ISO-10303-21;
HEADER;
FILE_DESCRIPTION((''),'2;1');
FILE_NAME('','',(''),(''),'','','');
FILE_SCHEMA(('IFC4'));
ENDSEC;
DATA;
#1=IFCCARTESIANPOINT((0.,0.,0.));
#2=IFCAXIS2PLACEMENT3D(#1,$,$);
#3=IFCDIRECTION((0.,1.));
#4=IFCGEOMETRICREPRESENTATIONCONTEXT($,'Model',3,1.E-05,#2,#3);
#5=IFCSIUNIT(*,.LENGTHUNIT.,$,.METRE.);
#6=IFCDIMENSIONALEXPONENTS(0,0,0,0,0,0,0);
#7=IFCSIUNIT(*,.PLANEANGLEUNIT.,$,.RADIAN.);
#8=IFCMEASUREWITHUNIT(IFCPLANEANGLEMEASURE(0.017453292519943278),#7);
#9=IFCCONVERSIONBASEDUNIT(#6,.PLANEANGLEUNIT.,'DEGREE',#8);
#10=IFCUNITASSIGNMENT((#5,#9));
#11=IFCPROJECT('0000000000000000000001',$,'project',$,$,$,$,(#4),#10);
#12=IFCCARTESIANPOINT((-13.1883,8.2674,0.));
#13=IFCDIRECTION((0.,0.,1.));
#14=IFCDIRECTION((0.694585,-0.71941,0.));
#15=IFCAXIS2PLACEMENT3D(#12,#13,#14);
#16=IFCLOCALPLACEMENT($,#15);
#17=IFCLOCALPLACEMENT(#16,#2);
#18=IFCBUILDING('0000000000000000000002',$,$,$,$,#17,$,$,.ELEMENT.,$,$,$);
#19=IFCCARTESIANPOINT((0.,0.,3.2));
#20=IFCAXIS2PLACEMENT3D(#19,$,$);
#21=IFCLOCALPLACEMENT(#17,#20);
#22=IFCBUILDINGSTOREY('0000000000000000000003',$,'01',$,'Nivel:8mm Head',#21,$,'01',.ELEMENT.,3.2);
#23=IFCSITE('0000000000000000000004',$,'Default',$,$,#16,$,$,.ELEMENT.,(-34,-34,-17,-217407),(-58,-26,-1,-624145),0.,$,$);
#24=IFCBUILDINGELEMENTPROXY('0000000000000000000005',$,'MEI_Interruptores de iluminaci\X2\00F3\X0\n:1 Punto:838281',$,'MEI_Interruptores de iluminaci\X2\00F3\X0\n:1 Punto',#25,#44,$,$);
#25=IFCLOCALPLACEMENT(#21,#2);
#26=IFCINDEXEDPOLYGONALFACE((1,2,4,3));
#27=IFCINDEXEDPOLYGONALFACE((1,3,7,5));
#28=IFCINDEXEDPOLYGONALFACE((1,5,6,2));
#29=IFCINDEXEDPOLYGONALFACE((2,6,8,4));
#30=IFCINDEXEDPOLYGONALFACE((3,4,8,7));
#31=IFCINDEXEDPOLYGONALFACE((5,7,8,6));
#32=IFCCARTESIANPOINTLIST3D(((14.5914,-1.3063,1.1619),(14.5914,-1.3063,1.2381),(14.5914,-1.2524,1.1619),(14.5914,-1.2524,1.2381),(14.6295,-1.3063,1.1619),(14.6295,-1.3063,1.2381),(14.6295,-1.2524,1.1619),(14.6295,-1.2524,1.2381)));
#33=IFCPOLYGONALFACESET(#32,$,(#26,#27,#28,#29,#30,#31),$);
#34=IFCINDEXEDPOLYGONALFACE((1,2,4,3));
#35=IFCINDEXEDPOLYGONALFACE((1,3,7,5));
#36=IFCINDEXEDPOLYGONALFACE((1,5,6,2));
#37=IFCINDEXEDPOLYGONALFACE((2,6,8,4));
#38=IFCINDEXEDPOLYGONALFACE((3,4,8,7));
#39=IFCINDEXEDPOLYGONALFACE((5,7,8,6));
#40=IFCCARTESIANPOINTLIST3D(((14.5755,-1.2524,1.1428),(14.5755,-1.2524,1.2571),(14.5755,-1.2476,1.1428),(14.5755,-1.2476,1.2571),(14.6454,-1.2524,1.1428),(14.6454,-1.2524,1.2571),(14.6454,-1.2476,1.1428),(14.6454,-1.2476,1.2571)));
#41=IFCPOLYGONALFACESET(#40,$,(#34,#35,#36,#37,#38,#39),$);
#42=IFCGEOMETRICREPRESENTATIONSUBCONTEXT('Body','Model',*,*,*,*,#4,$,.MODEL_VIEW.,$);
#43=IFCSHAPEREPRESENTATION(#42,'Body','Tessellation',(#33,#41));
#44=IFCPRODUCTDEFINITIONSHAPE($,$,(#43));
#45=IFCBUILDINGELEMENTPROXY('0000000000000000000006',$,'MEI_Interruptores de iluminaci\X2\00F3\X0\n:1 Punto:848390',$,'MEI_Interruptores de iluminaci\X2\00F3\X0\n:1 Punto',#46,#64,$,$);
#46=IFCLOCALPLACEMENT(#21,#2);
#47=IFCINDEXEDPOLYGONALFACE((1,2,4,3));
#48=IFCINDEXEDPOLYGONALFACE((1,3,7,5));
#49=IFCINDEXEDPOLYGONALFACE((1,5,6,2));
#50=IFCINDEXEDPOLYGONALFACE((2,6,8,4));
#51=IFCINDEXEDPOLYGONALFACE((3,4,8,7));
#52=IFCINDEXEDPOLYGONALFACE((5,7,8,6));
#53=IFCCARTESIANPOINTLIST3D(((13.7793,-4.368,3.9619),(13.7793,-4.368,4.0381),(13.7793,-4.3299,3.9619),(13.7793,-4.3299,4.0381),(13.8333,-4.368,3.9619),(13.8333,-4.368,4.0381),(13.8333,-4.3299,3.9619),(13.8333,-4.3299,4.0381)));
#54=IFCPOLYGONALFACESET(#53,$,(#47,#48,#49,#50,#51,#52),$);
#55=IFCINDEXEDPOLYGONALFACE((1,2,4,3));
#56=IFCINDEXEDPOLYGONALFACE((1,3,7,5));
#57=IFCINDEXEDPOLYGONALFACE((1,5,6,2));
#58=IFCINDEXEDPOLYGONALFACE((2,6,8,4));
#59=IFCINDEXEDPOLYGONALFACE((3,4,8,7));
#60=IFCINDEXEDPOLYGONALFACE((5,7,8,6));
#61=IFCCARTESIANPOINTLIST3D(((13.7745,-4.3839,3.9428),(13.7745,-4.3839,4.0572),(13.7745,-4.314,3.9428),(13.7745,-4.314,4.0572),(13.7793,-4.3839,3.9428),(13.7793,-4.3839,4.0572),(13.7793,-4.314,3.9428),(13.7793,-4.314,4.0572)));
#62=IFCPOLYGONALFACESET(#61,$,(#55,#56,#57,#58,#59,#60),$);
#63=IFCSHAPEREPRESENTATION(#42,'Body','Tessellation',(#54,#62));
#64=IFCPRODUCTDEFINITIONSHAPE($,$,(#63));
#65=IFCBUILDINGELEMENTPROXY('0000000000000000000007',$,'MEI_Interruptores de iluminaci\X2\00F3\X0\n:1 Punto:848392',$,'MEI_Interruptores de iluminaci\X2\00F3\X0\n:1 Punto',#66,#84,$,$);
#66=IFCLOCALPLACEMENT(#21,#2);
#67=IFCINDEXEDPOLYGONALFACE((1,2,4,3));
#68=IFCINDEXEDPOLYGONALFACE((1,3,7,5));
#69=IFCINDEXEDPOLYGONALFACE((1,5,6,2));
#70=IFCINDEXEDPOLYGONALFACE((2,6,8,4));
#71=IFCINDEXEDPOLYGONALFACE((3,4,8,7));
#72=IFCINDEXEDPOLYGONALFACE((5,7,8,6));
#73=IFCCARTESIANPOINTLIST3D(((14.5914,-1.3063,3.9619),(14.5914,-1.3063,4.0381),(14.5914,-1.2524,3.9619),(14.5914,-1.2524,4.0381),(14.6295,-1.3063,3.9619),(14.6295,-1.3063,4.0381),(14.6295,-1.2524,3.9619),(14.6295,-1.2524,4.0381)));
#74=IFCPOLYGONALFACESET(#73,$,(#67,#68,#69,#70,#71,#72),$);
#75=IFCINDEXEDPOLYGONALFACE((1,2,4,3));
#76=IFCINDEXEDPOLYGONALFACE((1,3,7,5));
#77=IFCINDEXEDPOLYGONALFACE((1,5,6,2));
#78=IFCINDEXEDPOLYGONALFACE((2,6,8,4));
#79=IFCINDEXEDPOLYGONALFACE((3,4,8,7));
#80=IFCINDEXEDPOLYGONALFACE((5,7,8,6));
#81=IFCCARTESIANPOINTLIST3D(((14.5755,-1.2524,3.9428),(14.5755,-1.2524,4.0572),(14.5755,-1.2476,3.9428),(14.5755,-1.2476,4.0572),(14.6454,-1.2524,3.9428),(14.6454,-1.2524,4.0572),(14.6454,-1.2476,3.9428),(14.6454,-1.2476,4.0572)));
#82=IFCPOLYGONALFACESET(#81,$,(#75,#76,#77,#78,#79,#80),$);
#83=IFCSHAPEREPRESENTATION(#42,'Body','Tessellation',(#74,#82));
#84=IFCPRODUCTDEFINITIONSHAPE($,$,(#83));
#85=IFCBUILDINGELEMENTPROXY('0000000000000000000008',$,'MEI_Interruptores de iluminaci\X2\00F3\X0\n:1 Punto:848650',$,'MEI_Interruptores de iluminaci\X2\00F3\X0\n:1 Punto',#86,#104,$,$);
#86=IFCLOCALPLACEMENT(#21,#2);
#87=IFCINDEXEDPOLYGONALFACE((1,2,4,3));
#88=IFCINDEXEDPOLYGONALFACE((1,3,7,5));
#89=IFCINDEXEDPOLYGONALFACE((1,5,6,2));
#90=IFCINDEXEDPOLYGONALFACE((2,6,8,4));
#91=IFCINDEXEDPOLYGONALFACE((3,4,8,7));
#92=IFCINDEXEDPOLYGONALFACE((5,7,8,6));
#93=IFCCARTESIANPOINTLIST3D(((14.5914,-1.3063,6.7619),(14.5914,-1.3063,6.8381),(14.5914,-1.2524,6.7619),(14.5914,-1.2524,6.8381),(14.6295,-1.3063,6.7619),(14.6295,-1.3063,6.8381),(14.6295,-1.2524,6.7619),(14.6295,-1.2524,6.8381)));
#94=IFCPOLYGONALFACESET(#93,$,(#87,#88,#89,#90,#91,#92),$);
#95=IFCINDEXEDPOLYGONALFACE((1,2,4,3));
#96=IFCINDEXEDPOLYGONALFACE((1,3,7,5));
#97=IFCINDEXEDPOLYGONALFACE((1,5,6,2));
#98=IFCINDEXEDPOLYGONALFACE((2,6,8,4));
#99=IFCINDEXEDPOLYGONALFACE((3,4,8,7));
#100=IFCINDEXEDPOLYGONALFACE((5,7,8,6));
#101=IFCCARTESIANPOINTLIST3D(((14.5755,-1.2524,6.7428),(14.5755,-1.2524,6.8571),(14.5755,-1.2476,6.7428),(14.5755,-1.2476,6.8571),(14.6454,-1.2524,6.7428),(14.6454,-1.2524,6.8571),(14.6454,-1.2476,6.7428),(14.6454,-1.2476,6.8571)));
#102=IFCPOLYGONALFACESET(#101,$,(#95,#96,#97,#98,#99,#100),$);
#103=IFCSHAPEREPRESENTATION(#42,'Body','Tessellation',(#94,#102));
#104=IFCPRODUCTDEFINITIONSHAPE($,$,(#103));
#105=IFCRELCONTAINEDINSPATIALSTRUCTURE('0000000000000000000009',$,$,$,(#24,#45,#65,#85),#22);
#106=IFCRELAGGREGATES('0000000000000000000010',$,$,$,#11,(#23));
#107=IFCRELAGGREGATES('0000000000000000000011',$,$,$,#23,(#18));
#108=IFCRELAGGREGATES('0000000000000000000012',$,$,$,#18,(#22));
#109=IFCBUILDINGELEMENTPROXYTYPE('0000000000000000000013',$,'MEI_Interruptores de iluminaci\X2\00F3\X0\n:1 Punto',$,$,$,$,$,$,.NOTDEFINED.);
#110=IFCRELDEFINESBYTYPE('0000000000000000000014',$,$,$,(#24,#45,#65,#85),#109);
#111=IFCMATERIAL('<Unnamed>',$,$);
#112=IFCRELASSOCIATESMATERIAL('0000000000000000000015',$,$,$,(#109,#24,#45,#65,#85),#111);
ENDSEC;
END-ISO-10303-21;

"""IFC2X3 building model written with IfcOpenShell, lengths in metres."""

from ifc_helpers import new_model, entity, si_unit, converted_unit, direction, frame, frame_2d, origin, origin_2d_with_axis, place, context, subcontext, project, spatial, rectangle, extrude, source, transform, mapped, material, type_object, type_shapes, element, save


model = new_model("IFC2X3")

# Units and contexts
model_context = context("Model", 3, precision=1e-05, world=origin(), true_north=direction((0.0, 1.0)))
body_context = subcontext(model_context, "Body", "Model", "MODEL_VIEW")
ifc_project = project(units=[si_unit("LENGTHUNIT", "METRE"), converted_unit("PLANEANGLEUNIT", "DEGREE", entity("IfcPlaneAngleMeasure", 0.017453292519943278), si_unit("PLANEANGLEUNIT", "RADIAN"), dimensions=[0, 0, 0, 0, 0, 0, 0])], contexts=[model_context])

# Site, building, storey
site_placement = place(None, frame((-13.1883, 8.2674, 0.0), z_axis=(0.0, 0.0, 1.0), x_axis=(0.694585, -0.71941, 0.0)))
site = spatial("IfcSite", under=ifc_project, at=site_placement, Name="Default", CompositionType="ELEMENT", RefLatitude=(-34, -34, -17, -217407), RefLongitude=(-58, -26, -1, -624145), RefElevation=0.0)
building_placement = place(site_placement, origin())
building = spatial("IfcBuilding", under=site, at=building_placement, CompositionType="ELEMENT")
storey_placement = place(building_placement, frame((0.0, 0.0, 3.2)))
storey = spatial("IfcBuildingStorey", under=building, at=storey_placement, Name="01", ObjectType="Nivel:8mm Head", LongName="01", CompositionType="ELEMENT", Elevation=3.2)

# Building element proxies
ifc_material_1 = material(Name="<Unnamed>")
building_element_proxy_type_1 = type_object("IfcBuildingElementProxyType", Name="MEI_Interruptores de iluminación:1 Punto", PredefinedType="NOTDEFINED", material=ifc_material_1)
shared_shape_1 = source(origin(), body_context, "Body", "SweptSolid", [
    extrude(rectangle(XDim=0.0381, YDim=0.0762, at=origin_2d_with_axis()), frame((0.0, 0.0, -0.054), z_axis=(0.0, 0.0, 1.0), x_axis=(-1.0, 0.0, 0.0)), (0.0, 0.0, 1.0), 0.054),
    extrude(rectangle(XDim=0.0698, YDim=0.1143, at=frame_2d((0.0, 0.0), x_axis=(1.0, 0.0))), frame((0.0, 0.0, 0.0), z_axis=(0.0, 0.0, 1.0), x_axis=(-1.0, 0.0, 0.0)), (0.0, 0.0, 1.0), 0.0048),
])
type_shapes(building_element_proxy_type_1, [shared_shape_1])
for number, where, z_axis, x_axis, name in (
    (1, (14.6104, -1.2524, 1.2), (0.0, 1.0, 0.0), (1.0, 0.0, 0.0), "MEI_Interruptores de iluminación:1 Punto:838281"),
    (2, (13.7793, -4.3489, 4.0), (-1.0, 0.0, 0.0), (0.0, -1.0, 0.0), "MEI_Interruptores de iluminación:1 Punto:848390"),
    (3, (14.6104, -1.2524, 4.0), (0.0, 1.0, 0.0), (1.0, 0.0, 0.0), "MEI_Interruptores de iluminación:1 Punto:848392"),
    (4, (14.6104, -1.2524, 6.8), (0.0, 1.0, 0.0), (1.0, 0.0, 0.0), "MEI_Interruptores de iluminación:1 Punto:848650"),
):
    element("IfcBuildingElementProxy", number, at=place(storey_placement, frame(where, z_axis=z_axis, x_axis=x_axis)), inside=storey, type_object=building_element_proxy_type_1, material=ifc_material_1, Name=name, ObjectType="MEI_Interruptores de iluminación:1 Punto", context=body_context, shape_type="MappedRepresentation", body=[
        mapped(shared_shape_1, transform((0.0, 0.0, 0.0), scale=1.0)),
    ])

save(model, "model.ifc")
